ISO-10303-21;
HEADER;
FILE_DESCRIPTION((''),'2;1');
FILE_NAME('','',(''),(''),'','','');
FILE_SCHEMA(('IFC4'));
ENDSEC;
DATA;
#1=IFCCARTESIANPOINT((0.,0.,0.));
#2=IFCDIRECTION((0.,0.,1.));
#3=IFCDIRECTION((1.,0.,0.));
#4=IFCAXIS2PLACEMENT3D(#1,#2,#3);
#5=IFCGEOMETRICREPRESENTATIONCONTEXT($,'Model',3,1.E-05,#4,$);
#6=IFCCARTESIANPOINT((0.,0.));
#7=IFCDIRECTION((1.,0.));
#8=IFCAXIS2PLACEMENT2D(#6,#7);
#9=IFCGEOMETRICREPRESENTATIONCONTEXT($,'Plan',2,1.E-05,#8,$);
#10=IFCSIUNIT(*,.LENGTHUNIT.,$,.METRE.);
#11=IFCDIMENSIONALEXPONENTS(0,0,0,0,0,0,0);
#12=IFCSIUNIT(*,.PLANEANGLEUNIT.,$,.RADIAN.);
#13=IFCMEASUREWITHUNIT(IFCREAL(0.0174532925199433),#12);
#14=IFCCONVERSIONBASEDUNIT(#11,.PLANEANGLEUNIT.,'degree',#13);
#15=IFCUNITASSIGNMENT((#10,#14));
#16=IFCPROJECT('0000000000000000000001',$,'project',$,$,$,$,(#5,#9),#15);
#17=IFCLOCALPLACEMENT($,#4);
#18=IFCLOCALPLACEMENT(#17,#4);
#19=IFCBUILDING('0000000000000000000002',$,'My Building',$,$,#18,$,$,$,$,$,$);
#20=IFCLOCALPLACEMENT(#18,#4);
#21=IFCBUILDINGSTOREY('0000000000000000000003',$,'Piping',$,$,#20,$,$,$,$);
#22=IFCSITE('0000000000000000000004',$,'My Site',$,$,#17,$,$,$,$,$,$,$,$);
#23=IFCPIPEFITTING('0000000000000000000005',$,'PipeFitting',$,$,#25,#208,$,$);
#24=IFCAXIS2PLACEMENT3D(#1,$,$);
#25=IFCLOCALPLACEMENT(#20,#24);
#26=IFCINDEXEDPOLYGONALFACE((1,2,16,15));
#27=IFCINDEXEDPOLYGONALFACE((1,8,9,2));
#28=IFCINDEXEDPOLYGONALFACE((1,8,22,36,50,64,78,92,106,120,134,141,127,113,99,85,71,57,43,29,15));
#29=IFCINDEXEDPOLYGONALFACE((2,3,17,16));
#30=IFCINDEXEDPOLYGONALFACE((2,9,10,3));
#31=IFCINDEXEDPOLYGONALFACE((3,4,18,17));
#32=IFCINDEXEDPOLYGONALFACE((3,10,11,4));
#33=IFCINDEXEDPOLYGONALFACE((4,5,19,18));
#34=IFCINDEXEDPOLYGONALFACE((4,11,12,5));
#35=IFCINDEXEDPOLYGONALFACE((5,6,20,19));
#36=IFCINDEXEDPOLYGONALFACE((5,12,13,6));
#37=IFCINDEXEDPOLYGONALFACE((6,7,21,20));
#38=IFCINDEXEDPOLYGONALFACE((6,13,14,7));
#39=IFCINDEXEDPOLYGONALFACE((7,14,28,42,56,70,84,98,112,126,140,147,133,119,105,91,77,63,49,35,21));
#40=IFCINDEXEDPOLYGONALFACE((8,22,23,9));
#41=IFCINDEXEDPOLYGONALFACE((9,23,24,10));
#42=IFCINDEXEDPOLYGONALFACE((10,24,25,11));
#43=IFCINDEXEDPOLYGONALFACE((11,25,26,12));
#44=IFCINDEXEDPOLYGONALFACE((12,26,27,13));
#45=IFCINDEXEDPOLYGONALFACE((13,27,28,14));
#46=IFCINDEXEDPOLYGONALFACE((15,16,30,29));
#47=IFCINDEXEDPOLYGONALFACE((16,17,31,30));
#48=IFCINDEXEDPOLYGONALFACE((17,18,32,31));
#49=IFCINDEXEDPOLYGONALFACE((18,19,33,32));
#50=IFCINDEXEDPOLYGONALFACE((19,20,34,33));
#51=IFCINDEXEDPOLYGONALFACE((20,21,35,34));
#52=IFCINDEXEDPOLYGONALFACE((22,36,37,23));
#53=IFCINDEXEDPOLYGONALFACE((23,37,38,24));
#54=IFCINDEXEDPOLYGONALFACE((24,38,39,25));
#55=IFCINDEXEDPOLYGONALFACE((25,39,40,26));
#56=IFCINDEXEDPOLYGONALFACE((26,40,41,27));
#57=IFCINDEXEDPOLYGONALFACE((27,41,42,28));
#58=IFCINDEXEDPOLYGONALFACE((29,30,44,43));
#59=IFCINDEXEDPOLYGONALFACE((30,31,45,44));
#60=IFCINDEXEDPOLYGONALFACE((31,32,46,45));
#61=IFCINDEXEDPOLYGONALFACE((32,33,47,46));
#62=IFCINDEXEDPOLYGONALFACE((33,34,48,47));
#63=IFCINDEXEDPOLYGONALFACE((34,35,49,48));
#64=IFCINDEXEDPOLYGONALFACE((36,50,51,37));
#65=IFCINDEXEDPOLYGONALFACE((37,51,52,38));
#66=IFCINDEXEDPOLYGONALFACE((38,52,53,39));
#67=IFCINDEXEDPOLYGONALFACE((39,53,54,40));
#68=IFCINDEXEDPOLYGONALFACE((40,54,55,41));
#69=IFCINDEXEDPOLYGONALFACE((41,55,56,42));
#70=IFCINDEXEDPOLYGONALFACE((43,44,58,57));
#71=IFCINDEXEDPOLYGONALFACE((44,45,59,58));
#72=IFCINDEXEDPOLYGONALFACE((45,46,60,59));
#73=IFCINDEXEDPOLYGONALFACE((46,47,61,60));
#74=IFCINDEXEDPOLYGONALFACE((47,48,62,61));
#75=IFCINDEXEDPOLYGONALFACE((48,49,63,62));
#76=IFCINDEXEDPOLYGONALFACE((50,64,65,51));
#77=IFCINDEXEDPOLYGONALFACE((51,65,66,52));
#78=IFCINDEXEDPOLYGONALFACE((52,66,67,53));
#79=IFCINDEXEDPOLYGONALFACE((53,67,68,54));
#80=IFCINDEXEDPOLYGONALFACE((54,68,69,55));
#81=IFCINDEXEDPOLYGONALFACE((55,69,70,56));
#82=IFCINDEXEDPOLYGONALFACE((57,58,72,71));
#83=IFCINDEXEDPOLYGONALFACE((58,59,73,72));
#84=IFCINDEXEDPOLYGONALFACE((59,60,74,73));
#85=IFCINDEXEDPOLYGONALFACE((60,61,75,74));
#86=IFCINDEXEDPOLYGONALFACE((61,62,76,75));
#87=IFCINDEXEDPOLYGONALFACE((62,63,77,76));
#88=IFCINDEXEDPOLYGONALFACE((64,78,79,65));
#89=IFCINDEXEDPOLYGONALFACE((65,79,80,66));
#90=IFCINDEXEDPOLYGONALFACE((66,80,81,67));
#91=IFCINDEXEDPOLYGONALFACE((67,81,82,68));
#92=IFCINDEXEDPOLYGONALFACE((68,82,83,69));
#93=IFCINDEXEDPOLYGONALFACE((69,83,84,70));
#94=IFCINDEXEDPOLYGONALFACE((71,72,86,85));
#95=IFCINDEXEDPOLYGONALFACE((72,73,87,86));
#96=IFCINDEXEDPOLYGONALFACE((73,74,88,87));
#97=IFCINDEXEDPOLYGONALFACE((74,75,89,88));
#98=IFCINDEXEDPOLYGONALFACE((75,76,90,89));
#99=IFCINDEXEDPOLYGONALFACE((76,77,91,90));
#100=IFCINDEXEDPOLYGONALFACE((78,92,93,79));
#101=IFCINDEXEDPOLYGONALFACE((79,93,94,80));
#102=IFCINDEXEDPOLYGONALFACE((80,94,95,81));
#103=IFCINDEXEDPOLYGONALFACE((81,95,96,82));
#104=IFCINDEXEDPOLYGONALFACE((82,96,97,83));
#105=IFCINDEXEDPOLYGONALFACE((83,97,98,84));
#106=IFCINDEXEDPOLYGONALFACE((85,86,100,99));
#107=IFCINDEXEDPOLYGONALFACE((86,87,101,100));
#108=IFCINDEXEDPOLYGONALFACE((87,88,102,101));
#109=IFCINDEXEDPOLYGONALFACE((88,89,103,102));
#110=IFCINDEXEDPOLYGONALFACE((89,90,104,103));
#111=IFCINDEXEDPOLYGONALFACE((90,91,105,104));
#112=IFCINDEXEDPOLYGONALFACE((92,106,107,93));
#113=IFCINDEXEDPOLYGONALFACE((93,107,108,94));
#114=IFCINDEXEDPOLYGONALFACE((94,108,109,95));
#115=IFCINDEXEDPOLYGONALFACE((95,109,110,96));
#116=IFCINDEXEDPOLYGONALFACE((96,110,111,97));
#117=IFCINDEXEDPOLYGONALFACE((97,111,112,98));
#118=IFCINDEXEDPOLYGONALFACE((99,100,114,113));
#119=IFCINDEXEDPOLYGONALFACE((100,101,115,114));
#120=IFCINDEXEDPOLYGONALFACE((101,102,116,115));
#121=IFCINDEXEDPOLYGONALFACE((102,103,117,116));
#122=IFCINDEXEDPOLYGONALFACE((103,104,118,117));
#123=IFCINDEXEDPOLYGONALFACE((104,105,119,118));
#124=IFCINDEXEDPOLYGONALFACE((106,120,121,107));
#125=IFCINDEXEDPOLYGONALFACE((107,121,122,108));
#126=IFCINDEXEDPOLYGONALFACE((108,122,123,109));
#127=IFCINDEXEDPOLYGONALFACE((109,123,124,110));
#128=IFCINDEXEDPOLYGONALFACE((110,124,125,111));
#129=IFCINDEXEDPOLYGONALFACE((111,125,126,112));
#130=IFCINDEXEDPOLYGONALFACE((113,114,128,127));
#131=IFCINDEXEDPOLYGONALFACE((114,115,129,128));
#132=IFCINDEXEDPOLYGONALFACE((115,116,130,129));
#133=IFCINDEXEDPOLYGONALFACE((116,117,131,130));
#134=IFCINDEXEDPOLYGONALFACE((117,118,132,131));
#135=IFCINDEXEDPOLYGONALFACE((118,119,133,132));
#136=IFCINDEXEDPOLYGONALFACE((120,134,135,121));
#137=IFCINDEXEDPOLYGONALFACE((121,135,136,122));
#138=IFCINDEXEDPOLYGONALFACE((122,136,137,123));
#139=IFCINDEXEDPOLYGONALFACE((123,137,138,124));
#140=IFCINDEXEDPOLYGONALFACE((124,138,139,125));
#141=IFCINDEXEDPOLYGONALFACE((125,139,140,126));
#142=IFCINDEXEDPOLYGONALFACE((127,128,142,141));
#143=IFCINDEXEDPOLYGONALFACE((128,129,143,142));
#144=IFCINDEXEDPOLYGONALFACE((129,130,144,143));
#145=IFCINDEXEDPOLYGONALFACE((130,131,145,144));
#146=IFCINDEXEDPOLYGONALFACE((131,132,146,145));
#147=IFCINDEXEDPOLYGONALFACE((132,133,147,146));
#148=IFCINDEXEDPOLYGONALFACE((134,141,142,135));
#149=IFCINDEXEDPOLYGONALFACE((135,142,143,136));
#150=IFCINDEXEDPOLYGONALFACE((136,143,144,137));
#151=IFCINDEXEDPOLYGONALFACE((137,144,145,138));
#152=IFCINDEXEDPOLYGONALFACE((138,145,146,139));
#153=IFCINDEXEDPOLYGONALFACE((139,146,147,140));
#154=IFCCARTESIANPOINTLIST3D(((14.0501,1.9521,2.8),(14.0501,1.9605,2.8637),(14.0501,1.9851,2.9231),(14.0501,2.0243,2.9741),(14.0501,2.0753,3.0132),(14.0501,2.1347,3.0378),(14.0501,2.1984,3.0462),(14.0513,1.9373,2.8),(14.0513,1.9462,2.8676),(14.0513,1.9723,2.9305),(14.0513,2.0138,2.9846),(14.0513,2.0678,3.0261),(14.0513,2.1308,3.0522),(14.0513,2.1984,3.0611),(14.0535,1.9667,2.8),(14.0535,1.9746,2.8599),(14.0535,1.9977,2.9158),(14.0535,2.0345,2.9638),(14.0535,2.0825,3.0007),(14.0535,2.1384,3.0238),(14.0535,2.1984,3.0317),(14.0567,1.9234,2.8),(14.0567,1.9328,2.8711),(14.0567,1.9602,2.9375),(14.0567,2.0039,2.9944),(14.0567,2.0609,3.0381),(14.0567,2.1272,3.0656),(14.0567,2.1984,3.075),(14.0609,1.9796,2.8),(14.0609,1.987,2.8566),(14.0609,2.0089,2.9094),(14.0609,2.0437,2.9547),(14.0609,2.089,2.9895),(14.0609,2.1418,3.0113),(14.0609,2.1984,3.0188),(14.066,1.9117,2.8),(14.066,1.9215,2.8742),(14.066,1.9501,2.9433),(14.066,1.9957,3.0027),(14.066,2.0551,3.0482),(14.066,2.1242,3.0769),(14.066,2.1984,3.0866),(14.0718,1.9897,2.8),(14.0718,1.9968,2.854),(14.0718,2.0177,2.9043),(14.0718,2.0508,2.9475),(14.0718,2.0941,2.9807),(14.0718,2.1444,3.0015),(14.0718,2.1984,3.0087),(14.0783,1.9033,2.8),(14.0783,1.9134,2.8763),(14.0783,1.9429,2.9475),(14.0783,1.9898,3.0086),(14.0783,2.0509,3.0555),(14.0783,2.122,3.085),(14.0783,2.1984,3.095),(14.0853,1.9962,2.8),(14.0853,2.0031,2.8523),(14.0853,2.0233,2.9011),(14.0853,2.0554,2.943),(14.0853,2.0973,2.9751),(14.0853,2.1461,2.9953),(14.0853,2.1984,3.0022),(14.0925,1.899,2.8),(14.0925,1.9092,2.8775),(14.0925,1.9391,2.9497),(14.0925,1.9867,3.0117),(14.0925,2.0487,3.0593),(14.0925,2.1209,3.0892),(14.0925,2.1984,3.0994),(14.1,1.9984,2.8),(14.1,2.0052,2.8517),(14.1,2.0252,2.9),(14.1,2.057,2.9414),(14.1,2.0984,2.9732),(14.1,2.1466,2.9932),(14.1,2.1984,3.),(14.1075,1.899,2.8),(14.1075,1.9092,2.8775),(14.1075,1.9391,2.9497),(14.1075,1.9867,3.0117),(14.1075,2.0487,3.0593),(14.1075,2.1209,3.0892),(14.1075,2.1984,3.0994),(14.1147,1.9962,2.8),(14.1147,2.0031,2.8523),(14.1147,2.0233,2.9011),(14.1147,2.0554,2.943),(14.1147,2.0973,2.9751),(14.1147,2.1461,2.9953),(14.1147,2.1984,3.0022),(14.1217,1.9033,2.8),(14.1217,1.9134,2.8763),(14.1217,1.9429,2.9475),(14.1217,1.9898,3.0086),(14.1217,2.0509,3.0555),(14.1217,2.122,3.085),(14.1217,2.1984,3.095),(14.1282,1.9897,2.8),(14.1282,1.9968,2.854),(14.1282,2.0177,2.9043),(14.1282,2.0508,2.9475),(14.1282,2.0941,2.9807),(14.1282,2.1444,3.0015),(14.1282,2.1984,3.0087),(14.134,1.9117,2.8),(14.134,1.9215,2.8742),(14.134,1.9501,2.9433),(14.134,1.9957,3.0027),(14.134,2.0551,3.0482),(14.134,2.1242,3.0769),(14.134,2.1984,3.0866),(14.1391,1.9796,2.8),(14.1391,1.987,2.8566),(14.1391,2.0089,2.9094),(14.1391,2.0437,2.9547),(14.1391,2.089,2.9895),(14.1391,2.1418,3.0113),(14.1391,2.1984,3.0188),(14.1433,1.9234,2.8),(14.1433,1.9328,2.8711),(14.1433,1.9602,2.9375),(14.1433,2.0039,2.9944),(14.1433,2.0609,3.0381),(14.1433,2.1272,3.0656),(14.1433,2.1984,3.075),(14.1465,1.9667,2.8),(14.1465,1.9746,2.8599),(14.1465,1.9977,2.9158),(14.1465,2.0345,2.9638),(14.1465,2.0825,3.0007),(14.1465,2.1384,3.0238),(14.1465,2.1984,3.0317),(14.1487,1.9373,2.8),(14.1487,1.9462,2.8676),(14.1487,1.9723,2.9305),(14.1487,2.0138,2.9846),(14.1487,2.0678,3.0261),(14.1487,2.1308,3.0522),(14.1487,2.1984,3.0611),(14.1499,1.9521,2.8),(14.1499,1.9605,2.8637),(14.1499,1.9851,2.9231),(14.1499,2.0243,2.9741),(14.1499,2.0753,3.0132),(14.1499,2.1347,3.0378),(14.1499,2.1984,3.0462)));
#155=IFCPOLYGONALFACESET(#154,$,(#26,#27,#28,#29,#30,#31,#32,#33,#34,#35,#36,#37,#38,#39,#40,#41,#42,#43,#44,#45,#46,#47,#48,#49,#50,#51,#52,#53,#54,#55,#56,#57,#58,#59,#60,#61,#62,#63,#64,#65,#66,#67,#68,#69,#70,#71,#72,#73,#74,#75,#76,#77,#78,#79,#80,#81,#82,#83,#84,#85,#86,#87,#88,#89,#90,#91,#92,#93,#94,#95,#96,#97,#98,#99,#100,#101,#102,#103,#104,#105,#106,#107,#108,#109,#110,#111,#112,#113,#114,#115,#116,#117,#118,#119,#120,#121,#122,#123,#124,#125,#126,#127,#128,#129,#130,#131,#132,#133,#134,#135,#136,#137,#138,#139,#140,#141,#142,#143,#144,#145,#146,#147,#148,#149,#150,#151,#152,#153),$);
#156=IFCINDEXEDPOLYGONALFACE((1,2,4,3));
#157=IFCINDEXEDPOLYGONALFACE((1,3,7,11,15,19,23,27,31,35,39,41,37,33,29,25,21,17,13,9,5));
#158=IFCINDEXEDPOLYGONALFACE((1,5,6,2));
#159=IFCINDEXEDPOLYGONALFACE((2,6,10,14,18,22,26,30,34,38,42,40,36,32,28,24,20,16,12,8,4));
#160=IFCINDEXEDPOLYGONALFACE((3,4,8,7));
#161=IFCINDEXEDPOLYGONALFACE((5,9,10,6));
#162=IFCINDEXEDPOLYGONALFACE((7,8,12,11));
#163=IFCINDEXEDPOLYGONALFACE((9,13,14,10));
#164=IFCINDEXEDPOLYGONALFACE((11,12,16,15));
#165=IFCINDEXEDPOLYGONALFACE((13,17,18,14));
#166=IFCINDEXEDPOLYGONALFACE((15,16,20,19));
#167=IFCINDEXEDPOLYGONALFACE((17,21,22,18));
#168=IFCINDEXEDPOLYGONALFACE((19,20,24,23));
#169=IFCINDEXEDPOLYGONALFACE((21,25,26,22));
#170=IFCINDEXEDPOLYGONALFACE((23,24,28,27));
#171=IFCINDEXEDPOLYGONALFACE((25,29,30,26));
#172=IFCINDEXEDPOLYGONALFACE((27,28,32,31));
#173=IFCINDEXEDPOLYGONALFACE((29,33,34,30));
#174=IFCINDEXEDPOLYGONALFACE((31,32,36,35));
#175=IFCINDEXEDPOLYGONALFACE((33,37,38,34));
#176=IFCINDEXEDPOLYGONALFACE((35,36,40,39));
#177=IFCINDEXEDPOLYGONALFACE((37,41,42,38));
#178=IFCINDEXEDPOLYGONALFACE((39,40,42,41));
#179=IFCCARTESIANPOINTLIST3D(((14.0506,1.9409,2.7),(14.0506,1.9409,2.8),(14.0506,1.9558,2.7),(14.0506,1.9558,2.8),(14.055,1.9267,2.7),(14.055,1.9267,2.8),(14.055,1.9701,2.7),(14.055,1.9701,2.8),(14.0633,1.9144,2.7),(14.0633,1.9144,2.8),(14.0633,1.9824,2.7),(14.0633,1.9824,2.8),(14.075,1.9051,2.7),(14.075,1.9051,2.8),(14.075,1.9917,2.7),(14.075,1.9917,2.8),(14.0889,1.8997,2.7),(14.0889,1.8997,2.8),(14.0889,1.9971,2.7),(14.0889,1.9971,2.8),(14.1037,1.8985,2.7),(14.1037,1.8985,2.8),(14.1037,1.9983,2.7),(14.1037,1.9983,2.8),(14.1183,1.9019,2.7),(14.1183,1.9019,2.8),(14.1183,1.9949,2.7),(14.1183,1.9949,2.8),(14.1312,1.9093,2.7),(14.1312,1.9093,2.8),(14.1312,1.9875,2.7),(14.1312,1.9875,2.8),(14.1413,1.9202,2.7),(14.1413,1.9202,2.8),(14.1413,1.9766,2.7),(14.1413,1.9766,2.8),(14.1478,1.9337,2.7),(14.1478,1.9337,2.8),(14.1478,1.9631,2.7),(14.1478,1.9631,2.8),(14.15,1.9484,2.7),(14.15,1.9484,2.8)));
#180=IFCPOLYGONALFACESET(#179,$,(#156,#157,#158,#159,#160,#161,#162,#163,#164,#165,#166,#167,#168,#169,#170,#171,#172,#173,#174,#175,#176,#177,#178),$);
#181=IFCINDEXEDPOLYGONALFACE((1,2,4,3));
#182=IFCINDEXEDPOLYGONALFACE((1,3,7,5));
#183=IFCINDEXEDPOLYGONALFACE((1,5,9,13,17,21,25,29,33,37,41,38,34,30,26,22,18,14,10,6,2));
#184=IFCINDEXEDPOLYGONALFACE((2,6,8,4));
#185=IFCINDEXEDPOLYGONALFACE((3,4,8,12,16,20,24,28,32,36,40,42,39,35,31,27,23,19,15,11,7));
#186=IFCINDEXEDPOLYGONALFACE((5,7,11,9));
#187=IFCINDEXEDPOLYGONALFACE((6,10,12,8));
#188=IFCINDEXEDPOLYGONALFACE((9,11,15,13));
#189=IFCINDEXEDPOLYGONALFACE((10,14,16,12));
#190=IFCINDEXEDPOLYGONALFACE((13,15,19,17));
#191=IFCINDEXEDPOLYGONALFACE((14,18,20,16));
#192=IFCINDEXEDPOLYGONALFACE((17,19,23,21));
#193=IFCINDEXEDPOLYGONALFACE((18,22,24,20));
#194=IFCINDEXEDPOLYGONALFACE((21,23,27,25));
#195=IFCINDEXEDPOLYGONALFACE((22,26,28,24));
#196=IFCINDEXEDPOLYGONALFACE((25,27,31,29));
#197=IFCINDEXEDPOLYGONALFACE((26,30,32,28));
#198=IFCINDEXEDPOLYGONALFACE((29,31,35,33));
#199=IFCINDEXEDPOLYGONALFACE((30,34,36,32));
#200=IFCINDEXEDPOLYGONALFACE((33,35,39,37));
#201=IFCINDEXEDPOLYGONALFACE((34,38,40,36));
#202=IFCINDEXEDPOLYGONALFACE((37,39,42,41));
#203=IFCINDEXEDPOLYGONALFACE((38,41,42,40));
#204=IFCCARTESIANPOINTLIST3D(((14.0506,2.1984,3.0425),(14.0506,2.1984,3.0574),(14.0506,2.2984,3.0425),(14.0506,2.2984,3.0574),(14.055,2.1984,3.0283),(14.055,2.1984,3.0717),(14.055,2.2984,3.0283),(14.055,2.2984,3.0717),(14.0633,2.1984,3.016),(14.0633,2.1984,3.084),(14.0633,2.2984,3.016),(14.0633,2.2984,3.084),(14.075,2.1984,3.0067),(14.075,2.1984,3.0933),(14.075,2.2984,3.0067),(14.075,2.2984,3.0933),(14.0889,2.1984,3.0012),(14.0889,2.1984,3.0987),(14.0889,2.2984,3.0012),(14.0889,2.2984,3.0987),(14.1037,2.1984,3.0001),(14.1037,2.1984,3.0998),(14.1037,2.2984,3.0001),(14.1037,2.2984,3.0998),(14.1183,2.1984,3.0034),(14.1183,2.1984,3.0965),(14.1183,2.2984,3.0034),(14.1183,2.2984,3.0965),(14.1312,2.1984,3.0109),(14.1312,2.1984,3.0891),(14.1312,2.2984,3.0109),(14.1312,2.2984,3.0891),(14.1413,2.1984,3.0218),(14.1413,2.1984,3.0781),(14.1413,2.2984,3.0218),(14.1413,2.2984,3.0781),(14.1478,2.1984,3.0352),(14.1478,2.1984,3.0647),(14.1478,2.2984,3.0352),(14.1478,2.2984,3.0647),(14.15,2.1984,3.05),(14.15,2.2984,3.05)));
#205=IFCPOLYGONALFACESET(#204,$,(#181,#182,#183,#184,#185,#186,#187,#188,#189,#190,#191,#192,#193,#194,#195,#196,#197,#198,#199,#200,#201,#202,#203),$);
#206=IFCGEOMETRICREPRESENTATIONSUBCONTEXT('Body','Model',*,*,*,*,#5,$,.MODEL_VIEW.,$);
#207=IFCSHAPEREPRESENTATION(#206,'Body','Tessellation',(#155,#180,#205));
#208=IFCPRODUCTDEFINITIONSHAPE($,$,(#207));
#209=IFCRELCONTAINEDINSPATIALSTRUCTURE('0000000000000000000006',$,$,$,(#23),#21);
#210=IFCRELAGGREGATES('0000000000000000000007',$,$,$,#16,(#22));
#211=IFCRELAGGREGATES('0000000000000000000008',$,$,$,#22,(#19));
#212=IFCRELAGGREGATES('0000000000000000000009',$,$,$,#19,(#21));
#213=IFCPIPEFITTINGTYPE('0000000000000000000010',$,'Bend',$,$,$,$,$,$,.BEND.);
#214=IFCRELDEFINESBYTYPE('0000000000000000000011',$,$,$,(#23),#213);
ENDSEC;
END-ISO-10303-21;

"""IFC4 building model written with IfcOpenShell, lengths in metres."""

from ifc_helpers import new_model, entity, si_unit, converted_unit, frame, origin_with_axes, origin_2d_with_axis, place, context, subcontext, project, spatial, circle, extrude, source, transform, mapped, type_object, type_shapes, element, save


model = new_model("IFC4")

# Units and contexts
model_context = context("Model", 3, precision=1e-05, world=origin_with_axes())
plan_context = context("Plan", 2, precision=1e-05, world=origin_2d_with_axis())
body_context = subcontext(model_context, "Body", "Model", "MODEL_VIEW")
ifc_project = project(units=[si_unit("LENGTHUNIT", "METRE"), converted_unit("PLANEANGLEUNIT", "degree", entity("IfcReal", 0.0174532925199433), si_unit("PLANEANGLEUNIT", "RADIAN"), dimensions=[0, 0, 0, 0, 0, 0, 0])], contexts=[model_context, plan_context])

# Site, building, storey
site_placement = place(None, origin_with_axes())
site = spatial("IfcSite", under=ifc_project, at=site_placement, Name="My Site")
building_placement = place(site_placement, origin_with_axes())
building = spatial("IfcBuilding", under=site, at=building_placement, Name="My Building")
storey_placement = place(building_placement, origin_with_axes())
storey = spatial("IfcBuildingStorey", under=building, at=storey_placement, Name="Piping")

# Pipe fitting
pipe_fitting_type_1 = type_object("IfcPipeFittingType", Name="Bend", PredefinedType="BEND")
shared_shape = source(origin_with_axes(), body_context, "Body", "SolidModel", [
    entity("IfcSweptDiskSolid", entity("IfcIndexedPolyCurve", entity("IfcCartesianPointList3D", [[0.0, 0.0, -0.1], [0.0, -0.0732, -0.2768], [0.0, -0.25, -0.35]]), [entity("IfcArcIndex", [1, 2, 3])]), 0.05),
    extrude(circle(Radius=0.05), origin_with_axes(), (0.0, 0.0, -1.0), 0.1),
    extrude(circle(Radius=0.05), frame((0.0, -0.25, -0.35), z_axis=(0.0, -1.0, 0.0), x_axis=(1.0, 0.0, 0.0)), (0.0, 0.0, 1.0), 0.1),
])
type_shapes(pipe_fitting_type_1, [shared_shape])
for number, where, z_axis, x_axis, name in (
    (1, (14.1, 1.9484, 2.7), (0.0, 0.0, -1.0), (1.0, 0.0, 0.0), "PipeFitting"),
):
    element("IfcPipeFitting", number, at=place(storey_placement, frame(where, z_axis=z_axis, x_axis=x_axis)), inside=storey, type_object=pipe_fitting_type_1, Name=name, context=body_context, shape_type="MappedRepresentation", body=[
        mapped(shared_shape, transform((0.0, 0.0, 0.0), x_axis=(1.0, 0.0, 0.0), y_axis=(0.0, 1.0, 0.0), z_axis=(0.0, 0.0, 1.0), scale=1.0)),
    ])

save(model, "model.ifc")
